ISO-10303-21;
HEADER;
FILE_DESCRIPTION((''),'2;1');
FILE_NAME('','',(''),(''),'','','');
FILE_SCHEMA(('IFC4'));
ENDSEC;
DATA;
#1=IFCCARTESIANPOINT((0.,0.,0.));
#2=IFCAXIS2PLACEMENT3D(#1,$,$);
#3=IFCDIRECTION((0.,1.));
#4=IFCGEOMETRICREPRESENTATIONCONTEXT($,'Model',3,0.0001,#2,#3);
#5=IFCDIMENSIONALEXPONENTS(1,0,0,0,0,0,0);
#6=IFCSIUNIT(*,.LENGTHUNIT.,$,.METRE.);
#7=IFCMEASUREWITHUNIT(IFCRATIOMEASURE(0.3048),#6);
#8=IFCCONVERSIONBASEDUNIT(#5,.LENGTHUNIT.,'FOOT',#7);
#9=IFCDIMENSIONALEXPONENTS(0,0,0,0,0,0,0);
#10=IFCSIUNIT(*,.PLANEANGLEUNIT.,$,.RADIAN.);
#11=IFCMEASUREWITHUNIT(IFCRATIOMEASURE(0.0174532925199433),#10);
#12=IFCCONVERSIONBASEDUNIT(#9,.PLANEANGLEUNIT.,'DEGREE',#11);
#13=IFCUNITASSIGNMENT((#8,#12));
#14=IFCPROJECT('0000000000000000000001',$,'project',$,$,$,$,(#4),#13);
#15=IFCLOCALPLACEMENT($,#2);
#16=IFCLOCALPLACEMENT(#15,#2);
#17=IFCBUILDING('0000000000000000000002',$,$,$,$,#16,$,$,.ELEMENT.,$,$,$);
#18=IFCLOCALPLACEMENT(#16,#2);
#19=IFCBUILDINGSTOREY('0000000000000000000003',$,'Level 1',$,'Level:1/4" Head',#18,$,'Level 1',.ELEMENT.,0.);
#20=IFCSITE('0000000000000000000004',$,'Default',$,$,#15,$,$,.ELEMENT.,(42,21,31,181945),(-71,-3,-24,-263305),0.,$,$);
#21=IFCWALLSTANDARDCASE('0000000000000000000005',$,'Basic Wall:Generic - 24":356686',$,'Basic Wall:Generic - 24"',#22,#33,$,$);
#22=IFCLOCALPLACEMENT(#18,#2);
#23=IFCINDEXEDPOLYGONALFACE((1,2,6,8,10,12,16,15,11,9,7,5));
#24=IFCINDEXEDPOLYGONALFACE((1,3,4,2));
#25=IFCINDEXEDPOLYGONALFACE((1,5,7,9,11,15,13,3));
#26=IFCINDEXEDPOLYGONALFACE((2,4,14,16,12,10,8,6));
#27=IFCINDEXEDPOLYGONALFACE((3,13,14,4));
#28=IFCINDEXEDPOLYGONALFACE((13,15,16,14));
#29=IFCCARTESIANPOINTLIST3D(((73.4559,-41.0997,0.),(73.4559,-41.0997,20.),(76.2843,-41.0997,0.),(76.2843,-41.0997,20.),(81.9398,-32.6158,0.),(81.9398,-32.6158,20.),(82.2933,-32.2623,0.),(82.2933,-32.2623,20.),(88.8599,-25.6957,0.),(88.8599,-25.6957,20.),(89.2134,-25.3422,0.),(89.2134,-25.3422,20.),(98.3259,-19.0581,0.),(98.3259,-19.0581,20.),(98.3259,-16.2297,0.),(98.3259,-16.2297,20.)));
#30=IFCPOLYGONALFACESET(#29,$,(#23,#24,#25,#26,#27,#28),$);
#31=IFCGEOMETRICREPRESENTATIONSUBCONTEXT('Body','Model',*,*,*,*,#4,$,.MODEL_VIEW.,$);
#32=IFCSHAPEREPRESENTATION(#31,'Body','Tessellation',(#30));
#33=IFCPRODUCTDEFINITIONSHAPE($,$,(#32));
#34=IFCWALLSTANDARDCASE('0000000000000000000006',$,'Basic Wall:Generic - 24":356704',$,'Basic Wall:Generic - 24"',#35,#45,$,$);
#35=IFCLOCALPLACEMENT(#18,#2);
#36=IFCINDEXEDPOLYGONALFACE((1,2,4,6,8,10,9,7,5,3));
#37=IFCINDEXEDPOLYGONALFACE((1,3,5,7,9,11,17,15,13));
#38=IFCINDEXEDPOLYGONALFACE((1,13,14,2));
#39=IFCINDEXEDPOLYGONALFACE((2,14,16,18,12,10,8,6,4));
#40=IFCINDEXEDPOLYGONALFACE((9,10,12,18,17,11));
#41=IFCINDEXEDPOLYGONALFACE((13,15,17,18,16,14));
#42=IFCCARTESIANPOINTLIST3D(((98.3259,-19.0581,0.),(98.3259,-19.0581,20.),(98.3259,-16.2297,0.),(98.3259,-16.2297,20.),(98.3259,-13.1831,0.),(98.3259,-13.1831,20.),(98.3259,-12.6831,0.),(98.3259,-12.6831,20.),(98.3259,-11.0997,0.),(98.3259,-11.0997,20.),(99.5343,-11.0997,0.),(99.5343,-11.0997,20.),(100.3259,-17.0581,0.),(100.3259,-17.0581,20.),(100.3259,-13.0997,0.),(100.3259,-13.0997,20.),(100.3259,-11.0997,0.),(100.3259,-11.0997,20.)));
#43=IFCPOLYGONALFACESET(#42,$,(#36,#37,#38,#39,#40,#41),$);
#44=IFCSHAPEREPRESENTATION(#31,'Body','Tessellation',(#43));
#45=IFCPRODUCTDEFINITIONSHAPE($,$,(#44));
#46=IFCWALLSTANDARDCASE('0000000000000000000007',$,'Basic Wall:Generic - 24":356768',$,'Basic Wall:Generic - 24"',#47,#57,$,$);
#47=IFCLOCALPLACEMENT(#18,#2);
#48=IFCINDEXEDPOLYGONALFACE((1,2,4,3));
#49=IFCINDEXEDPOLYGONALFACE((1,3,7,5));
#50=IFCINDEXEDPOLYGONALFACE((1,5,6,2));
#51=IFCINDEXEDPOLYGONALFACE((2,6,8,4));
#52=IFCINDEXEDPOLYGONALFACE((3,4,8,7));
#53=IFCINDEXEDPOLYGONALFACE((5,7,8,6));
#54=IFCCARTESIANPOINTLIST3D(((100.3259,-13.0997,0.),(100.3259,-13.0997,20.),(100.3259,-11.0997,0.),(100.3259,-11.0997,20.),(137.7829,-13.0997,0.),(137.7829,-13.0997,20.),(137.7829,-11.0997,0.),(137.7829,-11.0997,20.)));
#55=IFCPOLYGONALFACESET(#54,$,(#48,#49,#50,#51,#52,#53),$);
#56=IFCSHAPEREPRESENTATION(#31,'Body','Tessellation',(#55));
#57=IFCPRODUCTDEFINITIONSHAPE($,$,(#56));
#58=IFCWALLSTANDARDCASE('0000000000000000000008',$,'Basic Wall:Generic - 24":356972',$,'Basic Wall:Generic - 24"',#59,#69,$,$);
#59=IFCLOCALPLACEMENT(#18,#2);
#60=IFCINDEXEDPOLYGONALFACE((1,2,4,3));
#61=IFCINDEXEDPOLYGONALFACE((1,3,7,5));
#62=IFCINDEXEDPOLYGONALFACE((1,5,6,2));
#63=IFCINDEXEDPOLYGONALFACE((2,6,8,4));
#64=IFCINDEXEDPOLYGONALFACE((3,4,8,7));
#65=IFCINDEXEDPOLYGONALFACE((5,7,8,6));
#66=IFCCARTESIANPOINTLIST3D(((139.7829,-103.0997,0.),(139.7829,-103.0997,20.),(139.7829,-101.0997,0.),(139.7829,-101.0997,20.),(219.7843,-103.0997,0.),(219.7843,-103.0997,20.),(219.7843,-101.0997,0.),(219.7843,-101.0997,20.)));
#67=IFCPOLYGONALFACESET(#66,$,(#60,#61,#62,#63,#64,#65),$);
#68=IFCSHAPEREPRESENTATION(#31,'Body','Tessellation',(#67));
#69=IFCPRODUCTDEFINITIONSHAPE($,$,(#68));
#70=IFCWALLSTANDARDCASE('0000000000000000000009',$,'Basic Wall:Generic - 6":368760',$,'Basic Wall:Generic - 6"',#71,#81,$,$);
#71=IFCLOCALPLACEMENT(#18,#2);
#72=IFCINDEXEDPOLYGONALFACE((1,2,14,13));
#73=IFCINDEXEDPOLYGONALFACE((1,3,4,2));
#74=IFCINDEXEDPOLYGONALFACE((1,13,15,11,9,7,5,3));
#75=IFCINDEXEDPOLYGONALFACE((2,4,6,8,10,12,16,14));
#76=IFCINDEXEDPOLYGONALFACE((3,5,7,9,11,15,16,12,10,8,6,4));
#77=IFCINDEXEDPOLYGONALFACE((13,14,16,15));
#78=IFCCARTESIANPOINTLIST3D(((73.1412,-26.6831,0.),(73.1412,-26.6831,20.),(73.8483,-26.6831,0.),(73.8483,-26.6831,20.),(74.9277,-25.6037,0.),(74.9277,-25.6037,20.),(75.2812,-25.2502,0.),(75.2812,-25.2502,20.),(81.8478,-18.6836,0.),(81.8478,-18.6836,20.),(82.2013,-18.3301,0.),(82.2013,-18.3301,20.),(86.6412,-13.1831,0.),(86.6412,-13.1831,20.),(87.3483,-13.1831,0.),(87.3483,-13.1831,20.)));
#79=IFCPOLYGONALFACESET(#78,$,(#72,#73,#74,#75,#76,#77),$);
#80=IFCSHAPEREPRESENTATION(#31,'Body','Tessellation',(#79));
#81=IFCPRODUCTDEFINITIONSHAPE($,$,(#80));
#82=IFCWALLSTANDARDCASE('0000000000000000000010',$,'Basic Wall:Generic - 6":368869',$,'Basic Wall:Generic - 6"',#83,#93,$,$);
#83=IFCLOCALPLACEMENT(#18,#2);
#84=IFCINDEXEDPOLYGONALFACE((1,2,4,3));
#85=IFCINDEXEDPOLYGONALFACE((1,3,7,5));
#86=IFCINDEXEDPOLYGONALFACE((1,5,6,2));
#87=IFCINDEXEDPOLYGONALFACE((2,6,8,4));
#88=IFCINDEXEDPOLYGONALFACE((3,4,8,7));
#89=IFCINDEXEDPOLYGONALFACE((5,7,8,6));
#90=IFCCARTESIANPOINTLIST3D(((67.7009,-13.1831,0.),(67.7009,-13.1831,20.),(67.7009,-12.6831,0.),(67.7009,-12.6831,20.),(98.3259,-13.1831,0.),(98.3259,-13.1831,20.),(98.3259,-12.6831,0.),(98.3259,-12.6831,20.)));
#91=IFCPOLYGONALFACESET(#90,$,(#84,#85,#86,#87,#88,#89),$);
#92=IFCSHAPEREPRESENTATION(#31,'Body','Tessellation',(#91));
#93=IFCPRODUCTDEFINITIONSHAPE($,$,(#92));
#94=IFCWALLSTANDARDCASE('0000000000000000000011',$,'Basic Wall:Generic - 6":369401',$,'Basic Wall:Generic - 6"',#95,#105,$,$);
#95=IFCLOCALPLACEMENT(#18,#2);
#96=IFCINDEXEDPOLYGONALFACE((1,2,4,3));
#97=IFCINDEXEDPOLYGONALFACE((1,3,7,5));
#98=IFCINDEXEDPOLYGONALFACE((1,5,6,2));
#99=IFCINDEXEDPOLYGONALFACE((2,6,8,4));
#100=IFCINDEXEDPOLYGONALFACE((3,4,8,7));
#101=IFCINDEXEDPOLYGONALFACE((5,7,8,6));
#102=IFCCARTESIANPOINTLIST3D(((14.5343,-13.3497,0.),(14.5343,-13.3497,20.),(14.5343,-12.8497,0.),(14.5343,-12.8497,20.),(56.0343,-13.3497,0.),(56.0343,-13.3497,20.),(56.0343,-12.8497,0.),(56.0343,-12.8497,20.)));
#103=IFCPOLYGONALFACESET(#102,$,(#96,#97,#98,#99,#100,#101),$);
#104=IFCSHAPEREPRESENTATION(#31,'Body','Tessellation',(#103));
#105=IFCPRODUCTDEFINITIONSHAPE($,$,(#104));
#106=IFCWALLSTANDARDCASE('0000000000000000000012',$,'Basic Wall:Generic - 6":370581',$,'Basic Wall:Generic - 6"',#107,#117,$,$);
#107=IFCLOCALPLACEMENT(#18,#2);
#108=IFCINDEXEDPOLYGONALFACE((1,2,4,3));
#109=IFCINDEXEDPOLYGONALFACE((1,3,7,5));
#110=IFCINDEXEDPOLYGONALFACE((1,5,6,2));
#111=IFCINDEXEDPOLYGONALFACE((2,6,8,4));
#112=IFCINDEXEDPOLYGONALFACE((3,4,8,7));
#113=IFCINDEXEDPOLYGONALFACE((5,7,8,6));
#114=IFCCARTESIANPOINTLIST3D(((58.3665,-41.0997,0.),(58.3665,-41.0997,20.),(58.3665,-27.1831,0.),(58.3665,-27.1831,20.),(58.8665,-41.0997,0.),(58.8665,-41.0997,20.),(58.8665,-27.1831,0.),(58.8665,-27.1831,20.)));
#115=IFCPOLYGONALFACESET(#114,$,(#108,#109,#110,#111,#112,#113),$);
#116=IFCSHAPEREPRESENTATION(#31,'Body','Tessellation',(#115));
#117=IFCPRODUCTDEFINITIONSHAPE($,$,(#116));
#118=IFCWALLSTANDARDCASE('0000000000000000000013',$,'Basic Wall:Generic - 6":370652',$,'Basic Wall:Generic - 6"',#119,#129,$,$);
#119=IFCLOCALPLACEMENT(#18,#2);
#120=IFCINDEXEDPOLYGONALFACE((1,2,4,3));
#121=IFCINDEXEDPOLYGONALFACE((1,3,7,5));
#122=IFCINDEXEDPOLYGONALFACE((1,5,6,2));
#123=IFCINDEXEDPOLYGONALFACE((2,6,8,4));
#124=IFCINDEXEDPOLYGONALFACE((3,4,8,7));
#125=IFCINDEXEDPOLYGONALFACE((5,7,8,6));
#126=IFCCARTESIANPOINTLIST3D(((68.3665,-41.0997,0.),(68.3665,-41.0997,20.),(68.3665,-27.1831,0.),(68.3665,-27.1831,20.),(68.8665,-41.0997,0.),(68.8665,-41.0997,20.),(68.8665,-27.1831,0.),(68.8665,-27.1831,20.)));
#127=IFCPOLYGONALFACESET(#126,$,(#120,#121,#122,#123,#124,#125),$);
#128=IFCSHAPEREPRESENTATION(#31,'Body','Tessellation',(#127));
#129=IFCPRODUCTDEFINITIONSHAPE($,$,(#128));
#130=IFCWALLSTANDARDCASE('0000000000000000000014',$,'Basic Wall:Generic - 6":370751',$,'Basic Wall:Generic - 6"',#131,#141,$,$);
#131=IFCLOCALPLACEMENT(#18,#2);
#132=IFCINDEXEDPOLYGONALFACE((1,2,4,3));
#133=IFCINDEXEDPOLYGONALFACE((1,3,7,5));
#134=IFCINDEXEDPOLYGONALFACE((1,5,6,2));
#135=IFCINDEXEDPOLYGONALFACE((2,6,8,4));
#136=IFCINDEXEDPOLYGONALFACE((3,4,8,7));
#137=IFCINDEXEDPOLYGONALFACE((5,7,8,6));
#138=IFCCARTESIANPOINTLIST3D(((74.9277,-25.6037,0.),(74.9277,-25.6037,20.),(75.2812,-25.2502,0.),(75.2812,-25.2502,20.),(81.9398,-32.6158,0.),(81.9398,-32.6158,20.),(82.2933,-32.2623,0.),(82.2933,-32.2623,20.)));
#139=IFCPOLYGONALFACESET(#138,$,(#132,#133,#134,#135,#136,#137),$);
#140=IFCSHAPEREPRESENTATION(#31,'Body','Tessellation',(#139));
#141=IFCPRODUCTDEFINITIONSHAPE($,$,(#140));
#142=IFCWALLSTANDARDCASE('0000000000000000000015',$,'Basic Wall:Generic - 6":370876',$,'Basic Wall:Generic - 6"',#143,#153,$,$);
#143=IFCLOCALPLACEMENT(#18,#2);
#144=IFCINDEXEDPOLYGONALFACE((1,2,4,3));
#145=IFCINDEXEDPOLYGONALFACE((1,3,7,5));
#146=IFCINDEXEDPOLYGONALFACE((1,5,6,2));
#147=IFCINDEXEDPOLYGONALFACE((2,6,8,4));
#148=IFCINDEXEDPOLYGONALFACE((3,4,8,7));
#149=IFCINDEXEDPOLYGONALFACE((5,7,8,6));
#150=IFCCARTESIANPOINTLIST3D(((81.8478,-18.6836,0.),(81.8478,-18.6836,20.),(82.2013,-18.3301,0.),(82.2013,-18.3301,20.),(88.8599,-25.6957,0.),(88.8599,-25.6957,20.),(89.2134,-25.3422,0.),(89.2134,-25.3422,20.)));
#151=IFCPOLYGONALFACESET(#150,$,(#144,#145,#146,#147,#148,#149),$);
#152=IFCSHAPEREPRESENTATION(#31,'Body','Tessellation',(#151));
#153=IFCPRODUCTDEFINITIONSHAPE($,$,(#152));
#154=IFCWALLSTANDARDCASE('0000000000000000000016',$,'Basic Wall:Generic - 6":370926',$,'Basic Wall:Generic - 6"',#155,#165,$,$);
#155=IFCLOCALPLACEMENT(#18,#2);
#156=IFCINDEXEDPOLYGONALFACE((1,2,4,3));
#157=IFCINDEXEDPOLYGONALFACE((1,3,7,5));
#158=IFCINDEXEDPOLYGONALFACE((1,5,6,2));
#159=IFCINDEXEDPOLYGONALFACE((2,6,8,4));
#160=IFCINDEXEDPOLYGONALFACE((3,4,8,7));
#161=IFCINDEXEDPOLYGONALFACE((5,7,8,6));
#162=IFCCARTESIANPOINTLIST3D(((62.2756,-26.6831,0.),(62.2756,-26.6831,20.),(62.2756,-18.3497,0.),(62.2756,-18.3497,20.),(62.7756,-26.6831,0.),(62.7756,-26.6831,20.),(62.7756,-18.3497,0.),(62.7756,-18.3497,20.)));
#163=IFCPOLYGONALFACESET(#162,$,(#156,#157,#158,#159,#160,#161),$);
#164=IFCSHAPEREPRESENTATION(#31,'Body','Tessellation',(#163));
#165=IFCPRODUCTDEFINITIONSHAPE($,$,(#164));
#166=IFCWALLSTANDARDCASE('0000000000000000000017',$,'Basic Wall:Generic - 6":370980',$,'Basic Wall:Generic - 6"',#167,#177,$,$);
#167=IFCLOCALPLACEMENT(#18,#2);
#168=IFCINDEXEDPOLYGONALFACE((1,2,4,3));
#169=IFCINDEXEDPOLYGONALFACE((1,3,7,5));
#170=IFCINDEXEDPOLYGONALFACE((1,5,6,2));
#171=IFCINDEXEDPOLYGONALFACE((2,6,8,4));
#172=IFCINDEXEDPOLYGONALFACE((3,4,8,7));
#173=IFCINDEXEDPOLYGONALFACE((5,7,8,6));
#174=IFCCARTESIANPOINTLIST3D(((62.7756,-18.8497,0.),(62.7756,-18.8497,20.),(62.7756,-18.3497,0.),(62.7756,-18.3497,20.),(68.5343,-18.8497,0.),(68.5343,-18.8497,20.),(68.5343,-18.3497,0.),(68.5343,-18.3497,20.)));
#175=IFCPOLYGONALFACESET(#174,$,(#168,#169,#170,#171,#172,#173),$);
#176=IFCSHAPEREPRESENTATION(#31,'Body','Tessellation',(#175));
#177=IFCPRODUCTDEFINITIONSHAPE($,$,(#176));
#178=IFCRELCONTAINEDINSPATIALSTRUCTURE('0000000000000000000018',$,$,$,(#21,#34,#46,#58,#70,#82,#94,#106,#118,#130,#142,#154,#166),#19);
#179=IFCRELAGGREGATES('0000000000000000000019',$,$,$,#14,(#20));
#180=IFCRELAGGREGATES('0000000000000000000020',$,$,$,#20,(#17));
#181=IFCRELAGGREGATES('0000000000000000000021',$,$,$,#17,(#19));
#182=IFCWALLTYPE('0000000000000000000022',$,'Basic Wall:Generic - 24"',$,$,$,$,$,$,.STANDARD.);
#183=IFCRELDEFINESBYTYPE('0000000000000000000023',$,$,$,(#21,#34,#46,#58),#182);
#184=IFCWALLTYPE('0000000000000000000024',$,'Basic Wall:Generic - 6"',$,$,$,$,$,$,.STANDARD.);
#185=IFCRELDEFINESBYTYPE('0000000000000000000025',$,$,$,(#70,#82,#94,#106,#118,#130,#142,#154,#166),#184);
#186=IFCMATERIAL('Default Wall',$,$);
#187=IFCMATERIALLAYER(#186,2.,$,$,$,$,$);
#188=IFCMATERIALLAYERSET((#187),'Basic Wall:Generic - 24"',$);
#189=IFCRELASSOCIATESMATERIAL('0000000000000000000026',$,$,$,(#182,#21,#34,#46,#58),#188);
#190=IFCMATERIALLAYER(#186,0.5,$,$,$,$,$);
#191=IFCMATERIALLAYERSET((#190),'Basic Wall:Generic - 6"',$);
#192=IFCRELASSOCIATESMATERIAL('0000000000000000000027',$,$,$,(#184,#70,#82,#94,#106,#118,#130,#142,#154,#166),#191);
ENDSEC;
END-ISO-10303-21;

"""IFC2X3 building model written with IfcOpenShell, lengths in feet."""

from ifc_helpers import new_model, entity, si_unit, converted_unit, direction, frame, frame_2d, origin, place, context, subcontext, project, spatial, polyline, rectangle, outline, extrude, material, layer, layer_set, layer_usage, type_object, element, save


model = new_model("IFC2X3")

# Units and contexts
model_context = context("Model", 3, precision=0.0001, world=origin(), true_north=direction((0.0, 1.0)))
body_context = subcontext(model_context, "Body", "Model", "MODEL_VIEW")
ifc_project = project(units=[converted_unit("LENGTHUNIT", "FOOT", entity("IfcRatioMeasure", 0.3048), si_unit("LENGTHUNIT", "METRE"), dimensions=[1, 0, 0, 0, 0, 0, 0]), converted_unit("PLANEANGLEUNIT", "DEGREE", entity("IfcRatioMeasure", 0.0174532925199433), si_unit("PLANEANGLEUNIT", "RADIAN"), dimensions=[0, 0, 0, 0, 0, 0, 0])], contexts=[model_context])

# Site, building, storey
site_placement = place(None, origin())
site = spatial("IfcSite", under=ifc_project, at=site_placement, Name="Default", CompositionType="ELEMENT", RefLatitude=(42, 21, 31, 181945), RefLongitude=(-71, -3, -24, -263305), RefElevation=0.0)
building_placement = place(site_placement, origin())
building = spatial("IfcBuilding", under=site, at=building_placement, CompositionType="ELEMENT")
storey_placement = place(building_placement, origin())
storey = spatial("IfcBuildingStorey", under=building, at=storey_placement, Name="Level 1", ObjectType="Level:1/4\" Head", LongName="Level 1", CompositionType="ELEMENT", Elevation=0.0)

# Walls
ifc_material = material(Name="Default Wall")
ifc_layer_1 = layer(ifc_material, 2.0)
ifc_layer_set_1 = layer_set([ifc_layer_1], Name="Basic Wall:Generic - 24\"")
ifc_layer_usage_1 = layer_usage(ifc_layer_set_1, "AXIS2", "NEGATIVE", 1.0)
wall_type_1 = type_object("IfcWallType", Name="Basic Wall:Generic - 24\"", PredefinedType="STANDARD", material=ifc_layer_set_1)
wall_1_placement = place(storey_placement, frame((74.163, -41.8068, 0.0), z_axis=(0.0, 0.0, 1.0), x_axis=(0.707107, 0.707107, 0.0)))
element("IfcWallStandardCase", 1, at=wall_1_placement, inside=storey, type_object=wall_type_1, material=ifc_layer_usage_1, Name="Basic Wall:Generic - 24\":356686", ObjectType="Basic Wall:Generic - 24\"", context=body_context, shape_type="SweptSolid", body=[
    extrude(outline(polyline([(33.1716, -1.0), (35.1716, 1.0), (22.2846, 1.0), (21.7846, 1.0), (12.4981, 1.0), (11.9981, 1.0), (0.0, 1.0), (2.0, -1.0), (33.1716, -1.0)])), origin(), (0.0, 0.0, 1.0), 20.0),
])
ifc_layer_usage_2 = layer_usage(ifc_layer_set_1, "AXIS2", "NEGATIVE", 1.0)
wall_2_placement = place(storey_placement, frame((99.3259, -19.0581, 0.0), z_axis=(0.0, 0.0, 1.0), x_axis=(0.0, 1.0, 0.0)))
element("IfcWallStandardCase", 2, at=wall_2_placement, inside=storey, type_object=wall_type_1, material=ifc_layer_usage_2, Name="Basic Wall:Generic - 24\":356704", ObjectType="Basic Wall:Generic - 24\"", context=body_context, shape_type="SweptSolid", body=[
    extrude(outline(polyline([(7.9584, -1.0), (7.9584, -0.2083), (7.9584, 1.0), (6.375, 1.0), (5.875, 1.0), (2.8284, 1.0), (0.0, 1.0), (2.0, -1.0), (5.9584, -1.0), (7.9584, -1.0)])), origin(), (0.0, 0.0, 1.0), 20.0),
])
ifc_layer_usage_3 = layer_usage(ifc_layer_set_1, "AXIS2", "NEGATIVE", 1.0)
wall_3_placement = place(storey_placement, frame((100.3259, -12.0997, 0.0)))
element("IfcWallStandardCase", 3, at=wall_3_placement, inside=storey, type_object=wall_type_1, material=ifc_layer_usage_3, Name="Basic Wall:Generic - 24\":356768", ObjectType="Basic Wall:Generic - 24\"", context=body_context, shape_type="SweptSolid", body=[
    extrude(rectangle(XDim=37.457, YDim=2.0, at=frame_2d((18.7285, 0.0), x_axis=(-1.0, 0.0))), origin(), (0.0, 0.0, 1.0), 20.0),
])
ifc_layer_usage_4 = layer_usage(ifc_layer_set_1, "AXIS2", "NEGATIVE", 1.0)
wall_4_placement = place(storey_placement, frame((139.7829, -102.0997, 0.0)))
element("IfcWallStandardCase", 4, at=wall_4_placement, inside=storey, type_object=wall_type_1, material=ifc_layer_usage_4, Name="Basic Wall:Generic - 24\":356972", ObjectType="Basic Wall:Generic - 24\"", context=body_context, shape_type="SweptSolid", body=[
    extrude(rectangle(XDim=80.0014, YDim=2.0, at=frame_2d((40.0007, 0.0), x_axis=(-1.0, 0.0))), origin(), (0.0, 0.0, 1.0), 20.0),
])
ifc_layer_2 = layer(ifc_material, 0.5)
ifc_layer_set_2 = layer_set([ifc_layer_2], Name="Basic Wall:Generic - 6\"")
ifc_layer_usage_5 = layer_usage(ifc_layer_set_2, "AXIS2", "NEGATIVE", 0.25)
wall_type_2 = type_object("IfcWallType", Name="Basic Wall:Generic - 6\"", PredefinedType="STANDARD", material=ifc_layer_set_2)
wall_5_placement = place(storey_placement, frame((73.318, -26.8599, 0.0), z_axis=(0.0, 0.0, 1.0), x_axis=(0.707107, 0.707107, 0.0)))
element("IfcWallStandardCase", 5, at=wall_5_placement, inside=storey, type_object=wall_type_2, material=ifc_layer_usage_5, Name="Basic Wall:Generic - 6\":368760", ObjectType="Basic Wall:Generic - 6\"", context=body_context, shape_type="SweptSolid", body=[
    extrude(outline(polyline([(19.5919, -0.25), (19.0919, 0.25), (0.0, 0.25), (0.5, -0.25), (2.0265, -0.25), (2.5265, -0.25), (11.8129, -0.25), (12.3129, -0.25), (19.5919, -0.25)])), origin(), (0.0, 0.0, 1.0), 20.0),
])
ifc_layer_usage_6 = layer_usage(ifc_layer_set_2, "AXIS2", "NEGATIVE", 0.25)
wall_6_placement = place(storey_placement, frame((67.7009, -12.9331, 0.0)))
element("IfcWallStandardCase", 6, at=wall_6_placement, inside=storey, type_object=wall_type_2, material=ifc_layer_usage_6, Name="Basic Wall:Generic - 6\":368869", ObjectType="Basic Wall:Generic - 6\"", context=body_context, shape_type="SweptSolid", body=[
    extrude(rectangle(XDim=30.625, YDim=0.5, at=frame_2d((15.3125, 0.0), x_axis=(-1.0, 0.0))), origin(), (0.0, 0.0, 1.0), 20.0),
])
ifc_layer_usage_7 = layer_usage(ifc_layer_set_2, "AXIS2", "NEGATIVE", 0.25)
wall_7_placement = place(storey_placement, frame((56.0343, -13.0997, 0.0), z_axis=(0.0, 0.0, 1.0), x_axis=(-1.0, 0.0, 0.0)))
element("IfcWallStandardCase", 7, at=wall_7_placement, inside=storey, type_object=wall_type_2, material=ifc_layer_usage_7, Name="Basic Wall:Generic - 6\":369401", ObjectType="Basic Wall:Generic - 6\"", context=body_context, shape_type="SweptSolid", body=[
    extrude(rectangle(XDim=41.5, YDim=0.5, at=frame_2d((20.75, 0.0), x_axis=(-1.0, 0.0))), origin(), (0.0, 0.0, 1.0), 20.0),
])
ifc_layer_usage_8 = layer_usage(ifc_layer_set_2, "AXIS2", "NEGATIVE", 0.25)
wall_8_placement = place(storey_placement, frame((58.6165, -27.1831, 0.0), z_axis=(0.0, 0.0, 1.0), x_axis=(0.0, -1.0, 0.0)))
element("IfcWallStandardCase", 8, at=wall_8_placement, inside=storey, type_object=wall_type_2, material=ifc_layer_usage_8, Name="Basic Wall:Generic - 6\":370581", ObjectType="Basic Wall:Generic - 6\"", context=body_context, shape_type="SweptSolid", body=[
    extrude(rectangle(XDim=13.9167, YDim=0.5, at=frame_2d((6.9583, 0.0), x_axis=(-1.0, 0.0))), origin(), (0.0, 0.0, 1.0), 20.0),
])
ifc_layer_usage_9 = layer_usage(ifc_layer_set_2, "AXIS2", "NEGATIVE", 0.25)
wall_9_placement = place(storey_placement, frame((68.6165, -27.1831, 0.0), z_axis=(0.0, 0.0, 1.0), x_axis=(0.0, -1.0, 0.0)))
element("IfcWallStandardCase", 9, at=wall_9_placement, inside=storey, type_object=wall_type_2, material=ifc_layer_usage_9, Name="Basic Wall:Generic - 6\":370652", ObjectType="Basic Wall:Generic - 6\"", context=body_context, shape_type="SweptSolid", body=[
    extrude(rectangle(XDim=13.9167, YDim=0.5, at=frame_2d((6.9583, 0.0), x_axis=(-1.0, 0.0))), origin(), (0.0, 0.0, 1.0), 20.0),
])
ifc_layer_usage_10 = layer_usage(ifc_layer_set_2, "AXIS2", "NEGATIVE", 0.25)
wall_10_placement = place(storey_placement, frame((75.1045, -25.4269, 0.0), z_axis=(0.0, 0.0, 1.0), x_axis=(0.707107, -0.707107, 0.0)))
element("IfcWallStandardCase", 10, at=wall_10_placement, inside=storey, type_object=wall_type_2, material=ifc_layer_usage_10, Name="Basic Wall:Generic - 6\":370751", ObjectType="Basic Wall:Generic - 6\"", context=body_context, shape_type="SweptSolid", body=[
    extrude(rectangle(XDim=9.9166, YDim=0.5, at=frame_2d((4.9583, 0.0), x_axis=(-1.0, 0.0))), origin(), (0.0, 0.0, 1.0), 20.0),
])
ifc_layer_usage_11 = layer_usage(ifc_layer_set_2, "AXIS2", "NEGATIVE", 0.25)
wall_11_placement = place(storey_placement, frame((82.0245, -18.5068, 0.0), z_axis=(0.0, 0.0, 1.0), x_axis=(0.707107, -0.707107, 0.0)))
element("IfcWallStandardCase", 11, at=wall_11_placement, inside=storey, type_object=wall_type_2, material=ifc_layer_usage_11, Name="Basic Wall:Generic - 6\":370876", ObjectType="Basic Wall:Generic - 6\"", context=body_context, shape_type="SweptSolid", body=[
    extrude(rectangle(XDim=9.9166, YDim=0.5, at=frame_2d((4.9583, 0.0), x_axis=(-1.0, 0.0))), origin(), (0.0, 0.0, 1.0), 20.0),
])
ifc_layer_usage_12 = layer_usage(ifc_layer_set_2, "AXIS2", "NEGATIVE", 0.25)
wall_12_placement = place(storey_placement, frame((62.5256, -26.6831, 0.0), z_axis=(0.0, 0.0, 1.0), x_axis=(0.0, 1.0, 0.0)))
element("IfcWallStandardCase", 12, at=wall_12_placement, inside=storey, type_object=wall_type_2, material=ifc_layer_usage_12, Name="Basic Wall:Generic - 6\":370926", ObjectType="Basic Wall:Generic - 6\"", context=body_context, shape_type="SweptSolid", body=[
    extrude(rectangle(XDim=8.3333, YDim=0.5, at=frame_2d((4.1667, 0.0), x_axis=(-1.0, 0.0))), origin(), (0.0, 0.0, 1.0), 20.0),
])
ifc_layer_usage_13 = layer_usage(ifc_layer_set_2, "AXIS2", "NEGATIVE", 0.25)
wall_13_placement = place(storey_placement, frame((62.7756, -18.5997, 0.0)))
element("IfcWallStandardCase", 13, at=wall_13_placement, inside=storey, type_object=wall_type_2, material=ifc_layer_usage_13, Name="Basic Wall:Generic - 6\":370980", ObjectType="Basic Wall:Generic - 6\"", context=body_context, shape_type="SweptSolid", body=[
    extrude(rectangle(XDim=5.7586, YDim=0.5, at=frame_2d((2.8793, 0.0), x_axis=(-1.0, 0.0))), origin(), (0.0, 0.0, 1.0), 20.0),
])

save(model, "model.ifc")
